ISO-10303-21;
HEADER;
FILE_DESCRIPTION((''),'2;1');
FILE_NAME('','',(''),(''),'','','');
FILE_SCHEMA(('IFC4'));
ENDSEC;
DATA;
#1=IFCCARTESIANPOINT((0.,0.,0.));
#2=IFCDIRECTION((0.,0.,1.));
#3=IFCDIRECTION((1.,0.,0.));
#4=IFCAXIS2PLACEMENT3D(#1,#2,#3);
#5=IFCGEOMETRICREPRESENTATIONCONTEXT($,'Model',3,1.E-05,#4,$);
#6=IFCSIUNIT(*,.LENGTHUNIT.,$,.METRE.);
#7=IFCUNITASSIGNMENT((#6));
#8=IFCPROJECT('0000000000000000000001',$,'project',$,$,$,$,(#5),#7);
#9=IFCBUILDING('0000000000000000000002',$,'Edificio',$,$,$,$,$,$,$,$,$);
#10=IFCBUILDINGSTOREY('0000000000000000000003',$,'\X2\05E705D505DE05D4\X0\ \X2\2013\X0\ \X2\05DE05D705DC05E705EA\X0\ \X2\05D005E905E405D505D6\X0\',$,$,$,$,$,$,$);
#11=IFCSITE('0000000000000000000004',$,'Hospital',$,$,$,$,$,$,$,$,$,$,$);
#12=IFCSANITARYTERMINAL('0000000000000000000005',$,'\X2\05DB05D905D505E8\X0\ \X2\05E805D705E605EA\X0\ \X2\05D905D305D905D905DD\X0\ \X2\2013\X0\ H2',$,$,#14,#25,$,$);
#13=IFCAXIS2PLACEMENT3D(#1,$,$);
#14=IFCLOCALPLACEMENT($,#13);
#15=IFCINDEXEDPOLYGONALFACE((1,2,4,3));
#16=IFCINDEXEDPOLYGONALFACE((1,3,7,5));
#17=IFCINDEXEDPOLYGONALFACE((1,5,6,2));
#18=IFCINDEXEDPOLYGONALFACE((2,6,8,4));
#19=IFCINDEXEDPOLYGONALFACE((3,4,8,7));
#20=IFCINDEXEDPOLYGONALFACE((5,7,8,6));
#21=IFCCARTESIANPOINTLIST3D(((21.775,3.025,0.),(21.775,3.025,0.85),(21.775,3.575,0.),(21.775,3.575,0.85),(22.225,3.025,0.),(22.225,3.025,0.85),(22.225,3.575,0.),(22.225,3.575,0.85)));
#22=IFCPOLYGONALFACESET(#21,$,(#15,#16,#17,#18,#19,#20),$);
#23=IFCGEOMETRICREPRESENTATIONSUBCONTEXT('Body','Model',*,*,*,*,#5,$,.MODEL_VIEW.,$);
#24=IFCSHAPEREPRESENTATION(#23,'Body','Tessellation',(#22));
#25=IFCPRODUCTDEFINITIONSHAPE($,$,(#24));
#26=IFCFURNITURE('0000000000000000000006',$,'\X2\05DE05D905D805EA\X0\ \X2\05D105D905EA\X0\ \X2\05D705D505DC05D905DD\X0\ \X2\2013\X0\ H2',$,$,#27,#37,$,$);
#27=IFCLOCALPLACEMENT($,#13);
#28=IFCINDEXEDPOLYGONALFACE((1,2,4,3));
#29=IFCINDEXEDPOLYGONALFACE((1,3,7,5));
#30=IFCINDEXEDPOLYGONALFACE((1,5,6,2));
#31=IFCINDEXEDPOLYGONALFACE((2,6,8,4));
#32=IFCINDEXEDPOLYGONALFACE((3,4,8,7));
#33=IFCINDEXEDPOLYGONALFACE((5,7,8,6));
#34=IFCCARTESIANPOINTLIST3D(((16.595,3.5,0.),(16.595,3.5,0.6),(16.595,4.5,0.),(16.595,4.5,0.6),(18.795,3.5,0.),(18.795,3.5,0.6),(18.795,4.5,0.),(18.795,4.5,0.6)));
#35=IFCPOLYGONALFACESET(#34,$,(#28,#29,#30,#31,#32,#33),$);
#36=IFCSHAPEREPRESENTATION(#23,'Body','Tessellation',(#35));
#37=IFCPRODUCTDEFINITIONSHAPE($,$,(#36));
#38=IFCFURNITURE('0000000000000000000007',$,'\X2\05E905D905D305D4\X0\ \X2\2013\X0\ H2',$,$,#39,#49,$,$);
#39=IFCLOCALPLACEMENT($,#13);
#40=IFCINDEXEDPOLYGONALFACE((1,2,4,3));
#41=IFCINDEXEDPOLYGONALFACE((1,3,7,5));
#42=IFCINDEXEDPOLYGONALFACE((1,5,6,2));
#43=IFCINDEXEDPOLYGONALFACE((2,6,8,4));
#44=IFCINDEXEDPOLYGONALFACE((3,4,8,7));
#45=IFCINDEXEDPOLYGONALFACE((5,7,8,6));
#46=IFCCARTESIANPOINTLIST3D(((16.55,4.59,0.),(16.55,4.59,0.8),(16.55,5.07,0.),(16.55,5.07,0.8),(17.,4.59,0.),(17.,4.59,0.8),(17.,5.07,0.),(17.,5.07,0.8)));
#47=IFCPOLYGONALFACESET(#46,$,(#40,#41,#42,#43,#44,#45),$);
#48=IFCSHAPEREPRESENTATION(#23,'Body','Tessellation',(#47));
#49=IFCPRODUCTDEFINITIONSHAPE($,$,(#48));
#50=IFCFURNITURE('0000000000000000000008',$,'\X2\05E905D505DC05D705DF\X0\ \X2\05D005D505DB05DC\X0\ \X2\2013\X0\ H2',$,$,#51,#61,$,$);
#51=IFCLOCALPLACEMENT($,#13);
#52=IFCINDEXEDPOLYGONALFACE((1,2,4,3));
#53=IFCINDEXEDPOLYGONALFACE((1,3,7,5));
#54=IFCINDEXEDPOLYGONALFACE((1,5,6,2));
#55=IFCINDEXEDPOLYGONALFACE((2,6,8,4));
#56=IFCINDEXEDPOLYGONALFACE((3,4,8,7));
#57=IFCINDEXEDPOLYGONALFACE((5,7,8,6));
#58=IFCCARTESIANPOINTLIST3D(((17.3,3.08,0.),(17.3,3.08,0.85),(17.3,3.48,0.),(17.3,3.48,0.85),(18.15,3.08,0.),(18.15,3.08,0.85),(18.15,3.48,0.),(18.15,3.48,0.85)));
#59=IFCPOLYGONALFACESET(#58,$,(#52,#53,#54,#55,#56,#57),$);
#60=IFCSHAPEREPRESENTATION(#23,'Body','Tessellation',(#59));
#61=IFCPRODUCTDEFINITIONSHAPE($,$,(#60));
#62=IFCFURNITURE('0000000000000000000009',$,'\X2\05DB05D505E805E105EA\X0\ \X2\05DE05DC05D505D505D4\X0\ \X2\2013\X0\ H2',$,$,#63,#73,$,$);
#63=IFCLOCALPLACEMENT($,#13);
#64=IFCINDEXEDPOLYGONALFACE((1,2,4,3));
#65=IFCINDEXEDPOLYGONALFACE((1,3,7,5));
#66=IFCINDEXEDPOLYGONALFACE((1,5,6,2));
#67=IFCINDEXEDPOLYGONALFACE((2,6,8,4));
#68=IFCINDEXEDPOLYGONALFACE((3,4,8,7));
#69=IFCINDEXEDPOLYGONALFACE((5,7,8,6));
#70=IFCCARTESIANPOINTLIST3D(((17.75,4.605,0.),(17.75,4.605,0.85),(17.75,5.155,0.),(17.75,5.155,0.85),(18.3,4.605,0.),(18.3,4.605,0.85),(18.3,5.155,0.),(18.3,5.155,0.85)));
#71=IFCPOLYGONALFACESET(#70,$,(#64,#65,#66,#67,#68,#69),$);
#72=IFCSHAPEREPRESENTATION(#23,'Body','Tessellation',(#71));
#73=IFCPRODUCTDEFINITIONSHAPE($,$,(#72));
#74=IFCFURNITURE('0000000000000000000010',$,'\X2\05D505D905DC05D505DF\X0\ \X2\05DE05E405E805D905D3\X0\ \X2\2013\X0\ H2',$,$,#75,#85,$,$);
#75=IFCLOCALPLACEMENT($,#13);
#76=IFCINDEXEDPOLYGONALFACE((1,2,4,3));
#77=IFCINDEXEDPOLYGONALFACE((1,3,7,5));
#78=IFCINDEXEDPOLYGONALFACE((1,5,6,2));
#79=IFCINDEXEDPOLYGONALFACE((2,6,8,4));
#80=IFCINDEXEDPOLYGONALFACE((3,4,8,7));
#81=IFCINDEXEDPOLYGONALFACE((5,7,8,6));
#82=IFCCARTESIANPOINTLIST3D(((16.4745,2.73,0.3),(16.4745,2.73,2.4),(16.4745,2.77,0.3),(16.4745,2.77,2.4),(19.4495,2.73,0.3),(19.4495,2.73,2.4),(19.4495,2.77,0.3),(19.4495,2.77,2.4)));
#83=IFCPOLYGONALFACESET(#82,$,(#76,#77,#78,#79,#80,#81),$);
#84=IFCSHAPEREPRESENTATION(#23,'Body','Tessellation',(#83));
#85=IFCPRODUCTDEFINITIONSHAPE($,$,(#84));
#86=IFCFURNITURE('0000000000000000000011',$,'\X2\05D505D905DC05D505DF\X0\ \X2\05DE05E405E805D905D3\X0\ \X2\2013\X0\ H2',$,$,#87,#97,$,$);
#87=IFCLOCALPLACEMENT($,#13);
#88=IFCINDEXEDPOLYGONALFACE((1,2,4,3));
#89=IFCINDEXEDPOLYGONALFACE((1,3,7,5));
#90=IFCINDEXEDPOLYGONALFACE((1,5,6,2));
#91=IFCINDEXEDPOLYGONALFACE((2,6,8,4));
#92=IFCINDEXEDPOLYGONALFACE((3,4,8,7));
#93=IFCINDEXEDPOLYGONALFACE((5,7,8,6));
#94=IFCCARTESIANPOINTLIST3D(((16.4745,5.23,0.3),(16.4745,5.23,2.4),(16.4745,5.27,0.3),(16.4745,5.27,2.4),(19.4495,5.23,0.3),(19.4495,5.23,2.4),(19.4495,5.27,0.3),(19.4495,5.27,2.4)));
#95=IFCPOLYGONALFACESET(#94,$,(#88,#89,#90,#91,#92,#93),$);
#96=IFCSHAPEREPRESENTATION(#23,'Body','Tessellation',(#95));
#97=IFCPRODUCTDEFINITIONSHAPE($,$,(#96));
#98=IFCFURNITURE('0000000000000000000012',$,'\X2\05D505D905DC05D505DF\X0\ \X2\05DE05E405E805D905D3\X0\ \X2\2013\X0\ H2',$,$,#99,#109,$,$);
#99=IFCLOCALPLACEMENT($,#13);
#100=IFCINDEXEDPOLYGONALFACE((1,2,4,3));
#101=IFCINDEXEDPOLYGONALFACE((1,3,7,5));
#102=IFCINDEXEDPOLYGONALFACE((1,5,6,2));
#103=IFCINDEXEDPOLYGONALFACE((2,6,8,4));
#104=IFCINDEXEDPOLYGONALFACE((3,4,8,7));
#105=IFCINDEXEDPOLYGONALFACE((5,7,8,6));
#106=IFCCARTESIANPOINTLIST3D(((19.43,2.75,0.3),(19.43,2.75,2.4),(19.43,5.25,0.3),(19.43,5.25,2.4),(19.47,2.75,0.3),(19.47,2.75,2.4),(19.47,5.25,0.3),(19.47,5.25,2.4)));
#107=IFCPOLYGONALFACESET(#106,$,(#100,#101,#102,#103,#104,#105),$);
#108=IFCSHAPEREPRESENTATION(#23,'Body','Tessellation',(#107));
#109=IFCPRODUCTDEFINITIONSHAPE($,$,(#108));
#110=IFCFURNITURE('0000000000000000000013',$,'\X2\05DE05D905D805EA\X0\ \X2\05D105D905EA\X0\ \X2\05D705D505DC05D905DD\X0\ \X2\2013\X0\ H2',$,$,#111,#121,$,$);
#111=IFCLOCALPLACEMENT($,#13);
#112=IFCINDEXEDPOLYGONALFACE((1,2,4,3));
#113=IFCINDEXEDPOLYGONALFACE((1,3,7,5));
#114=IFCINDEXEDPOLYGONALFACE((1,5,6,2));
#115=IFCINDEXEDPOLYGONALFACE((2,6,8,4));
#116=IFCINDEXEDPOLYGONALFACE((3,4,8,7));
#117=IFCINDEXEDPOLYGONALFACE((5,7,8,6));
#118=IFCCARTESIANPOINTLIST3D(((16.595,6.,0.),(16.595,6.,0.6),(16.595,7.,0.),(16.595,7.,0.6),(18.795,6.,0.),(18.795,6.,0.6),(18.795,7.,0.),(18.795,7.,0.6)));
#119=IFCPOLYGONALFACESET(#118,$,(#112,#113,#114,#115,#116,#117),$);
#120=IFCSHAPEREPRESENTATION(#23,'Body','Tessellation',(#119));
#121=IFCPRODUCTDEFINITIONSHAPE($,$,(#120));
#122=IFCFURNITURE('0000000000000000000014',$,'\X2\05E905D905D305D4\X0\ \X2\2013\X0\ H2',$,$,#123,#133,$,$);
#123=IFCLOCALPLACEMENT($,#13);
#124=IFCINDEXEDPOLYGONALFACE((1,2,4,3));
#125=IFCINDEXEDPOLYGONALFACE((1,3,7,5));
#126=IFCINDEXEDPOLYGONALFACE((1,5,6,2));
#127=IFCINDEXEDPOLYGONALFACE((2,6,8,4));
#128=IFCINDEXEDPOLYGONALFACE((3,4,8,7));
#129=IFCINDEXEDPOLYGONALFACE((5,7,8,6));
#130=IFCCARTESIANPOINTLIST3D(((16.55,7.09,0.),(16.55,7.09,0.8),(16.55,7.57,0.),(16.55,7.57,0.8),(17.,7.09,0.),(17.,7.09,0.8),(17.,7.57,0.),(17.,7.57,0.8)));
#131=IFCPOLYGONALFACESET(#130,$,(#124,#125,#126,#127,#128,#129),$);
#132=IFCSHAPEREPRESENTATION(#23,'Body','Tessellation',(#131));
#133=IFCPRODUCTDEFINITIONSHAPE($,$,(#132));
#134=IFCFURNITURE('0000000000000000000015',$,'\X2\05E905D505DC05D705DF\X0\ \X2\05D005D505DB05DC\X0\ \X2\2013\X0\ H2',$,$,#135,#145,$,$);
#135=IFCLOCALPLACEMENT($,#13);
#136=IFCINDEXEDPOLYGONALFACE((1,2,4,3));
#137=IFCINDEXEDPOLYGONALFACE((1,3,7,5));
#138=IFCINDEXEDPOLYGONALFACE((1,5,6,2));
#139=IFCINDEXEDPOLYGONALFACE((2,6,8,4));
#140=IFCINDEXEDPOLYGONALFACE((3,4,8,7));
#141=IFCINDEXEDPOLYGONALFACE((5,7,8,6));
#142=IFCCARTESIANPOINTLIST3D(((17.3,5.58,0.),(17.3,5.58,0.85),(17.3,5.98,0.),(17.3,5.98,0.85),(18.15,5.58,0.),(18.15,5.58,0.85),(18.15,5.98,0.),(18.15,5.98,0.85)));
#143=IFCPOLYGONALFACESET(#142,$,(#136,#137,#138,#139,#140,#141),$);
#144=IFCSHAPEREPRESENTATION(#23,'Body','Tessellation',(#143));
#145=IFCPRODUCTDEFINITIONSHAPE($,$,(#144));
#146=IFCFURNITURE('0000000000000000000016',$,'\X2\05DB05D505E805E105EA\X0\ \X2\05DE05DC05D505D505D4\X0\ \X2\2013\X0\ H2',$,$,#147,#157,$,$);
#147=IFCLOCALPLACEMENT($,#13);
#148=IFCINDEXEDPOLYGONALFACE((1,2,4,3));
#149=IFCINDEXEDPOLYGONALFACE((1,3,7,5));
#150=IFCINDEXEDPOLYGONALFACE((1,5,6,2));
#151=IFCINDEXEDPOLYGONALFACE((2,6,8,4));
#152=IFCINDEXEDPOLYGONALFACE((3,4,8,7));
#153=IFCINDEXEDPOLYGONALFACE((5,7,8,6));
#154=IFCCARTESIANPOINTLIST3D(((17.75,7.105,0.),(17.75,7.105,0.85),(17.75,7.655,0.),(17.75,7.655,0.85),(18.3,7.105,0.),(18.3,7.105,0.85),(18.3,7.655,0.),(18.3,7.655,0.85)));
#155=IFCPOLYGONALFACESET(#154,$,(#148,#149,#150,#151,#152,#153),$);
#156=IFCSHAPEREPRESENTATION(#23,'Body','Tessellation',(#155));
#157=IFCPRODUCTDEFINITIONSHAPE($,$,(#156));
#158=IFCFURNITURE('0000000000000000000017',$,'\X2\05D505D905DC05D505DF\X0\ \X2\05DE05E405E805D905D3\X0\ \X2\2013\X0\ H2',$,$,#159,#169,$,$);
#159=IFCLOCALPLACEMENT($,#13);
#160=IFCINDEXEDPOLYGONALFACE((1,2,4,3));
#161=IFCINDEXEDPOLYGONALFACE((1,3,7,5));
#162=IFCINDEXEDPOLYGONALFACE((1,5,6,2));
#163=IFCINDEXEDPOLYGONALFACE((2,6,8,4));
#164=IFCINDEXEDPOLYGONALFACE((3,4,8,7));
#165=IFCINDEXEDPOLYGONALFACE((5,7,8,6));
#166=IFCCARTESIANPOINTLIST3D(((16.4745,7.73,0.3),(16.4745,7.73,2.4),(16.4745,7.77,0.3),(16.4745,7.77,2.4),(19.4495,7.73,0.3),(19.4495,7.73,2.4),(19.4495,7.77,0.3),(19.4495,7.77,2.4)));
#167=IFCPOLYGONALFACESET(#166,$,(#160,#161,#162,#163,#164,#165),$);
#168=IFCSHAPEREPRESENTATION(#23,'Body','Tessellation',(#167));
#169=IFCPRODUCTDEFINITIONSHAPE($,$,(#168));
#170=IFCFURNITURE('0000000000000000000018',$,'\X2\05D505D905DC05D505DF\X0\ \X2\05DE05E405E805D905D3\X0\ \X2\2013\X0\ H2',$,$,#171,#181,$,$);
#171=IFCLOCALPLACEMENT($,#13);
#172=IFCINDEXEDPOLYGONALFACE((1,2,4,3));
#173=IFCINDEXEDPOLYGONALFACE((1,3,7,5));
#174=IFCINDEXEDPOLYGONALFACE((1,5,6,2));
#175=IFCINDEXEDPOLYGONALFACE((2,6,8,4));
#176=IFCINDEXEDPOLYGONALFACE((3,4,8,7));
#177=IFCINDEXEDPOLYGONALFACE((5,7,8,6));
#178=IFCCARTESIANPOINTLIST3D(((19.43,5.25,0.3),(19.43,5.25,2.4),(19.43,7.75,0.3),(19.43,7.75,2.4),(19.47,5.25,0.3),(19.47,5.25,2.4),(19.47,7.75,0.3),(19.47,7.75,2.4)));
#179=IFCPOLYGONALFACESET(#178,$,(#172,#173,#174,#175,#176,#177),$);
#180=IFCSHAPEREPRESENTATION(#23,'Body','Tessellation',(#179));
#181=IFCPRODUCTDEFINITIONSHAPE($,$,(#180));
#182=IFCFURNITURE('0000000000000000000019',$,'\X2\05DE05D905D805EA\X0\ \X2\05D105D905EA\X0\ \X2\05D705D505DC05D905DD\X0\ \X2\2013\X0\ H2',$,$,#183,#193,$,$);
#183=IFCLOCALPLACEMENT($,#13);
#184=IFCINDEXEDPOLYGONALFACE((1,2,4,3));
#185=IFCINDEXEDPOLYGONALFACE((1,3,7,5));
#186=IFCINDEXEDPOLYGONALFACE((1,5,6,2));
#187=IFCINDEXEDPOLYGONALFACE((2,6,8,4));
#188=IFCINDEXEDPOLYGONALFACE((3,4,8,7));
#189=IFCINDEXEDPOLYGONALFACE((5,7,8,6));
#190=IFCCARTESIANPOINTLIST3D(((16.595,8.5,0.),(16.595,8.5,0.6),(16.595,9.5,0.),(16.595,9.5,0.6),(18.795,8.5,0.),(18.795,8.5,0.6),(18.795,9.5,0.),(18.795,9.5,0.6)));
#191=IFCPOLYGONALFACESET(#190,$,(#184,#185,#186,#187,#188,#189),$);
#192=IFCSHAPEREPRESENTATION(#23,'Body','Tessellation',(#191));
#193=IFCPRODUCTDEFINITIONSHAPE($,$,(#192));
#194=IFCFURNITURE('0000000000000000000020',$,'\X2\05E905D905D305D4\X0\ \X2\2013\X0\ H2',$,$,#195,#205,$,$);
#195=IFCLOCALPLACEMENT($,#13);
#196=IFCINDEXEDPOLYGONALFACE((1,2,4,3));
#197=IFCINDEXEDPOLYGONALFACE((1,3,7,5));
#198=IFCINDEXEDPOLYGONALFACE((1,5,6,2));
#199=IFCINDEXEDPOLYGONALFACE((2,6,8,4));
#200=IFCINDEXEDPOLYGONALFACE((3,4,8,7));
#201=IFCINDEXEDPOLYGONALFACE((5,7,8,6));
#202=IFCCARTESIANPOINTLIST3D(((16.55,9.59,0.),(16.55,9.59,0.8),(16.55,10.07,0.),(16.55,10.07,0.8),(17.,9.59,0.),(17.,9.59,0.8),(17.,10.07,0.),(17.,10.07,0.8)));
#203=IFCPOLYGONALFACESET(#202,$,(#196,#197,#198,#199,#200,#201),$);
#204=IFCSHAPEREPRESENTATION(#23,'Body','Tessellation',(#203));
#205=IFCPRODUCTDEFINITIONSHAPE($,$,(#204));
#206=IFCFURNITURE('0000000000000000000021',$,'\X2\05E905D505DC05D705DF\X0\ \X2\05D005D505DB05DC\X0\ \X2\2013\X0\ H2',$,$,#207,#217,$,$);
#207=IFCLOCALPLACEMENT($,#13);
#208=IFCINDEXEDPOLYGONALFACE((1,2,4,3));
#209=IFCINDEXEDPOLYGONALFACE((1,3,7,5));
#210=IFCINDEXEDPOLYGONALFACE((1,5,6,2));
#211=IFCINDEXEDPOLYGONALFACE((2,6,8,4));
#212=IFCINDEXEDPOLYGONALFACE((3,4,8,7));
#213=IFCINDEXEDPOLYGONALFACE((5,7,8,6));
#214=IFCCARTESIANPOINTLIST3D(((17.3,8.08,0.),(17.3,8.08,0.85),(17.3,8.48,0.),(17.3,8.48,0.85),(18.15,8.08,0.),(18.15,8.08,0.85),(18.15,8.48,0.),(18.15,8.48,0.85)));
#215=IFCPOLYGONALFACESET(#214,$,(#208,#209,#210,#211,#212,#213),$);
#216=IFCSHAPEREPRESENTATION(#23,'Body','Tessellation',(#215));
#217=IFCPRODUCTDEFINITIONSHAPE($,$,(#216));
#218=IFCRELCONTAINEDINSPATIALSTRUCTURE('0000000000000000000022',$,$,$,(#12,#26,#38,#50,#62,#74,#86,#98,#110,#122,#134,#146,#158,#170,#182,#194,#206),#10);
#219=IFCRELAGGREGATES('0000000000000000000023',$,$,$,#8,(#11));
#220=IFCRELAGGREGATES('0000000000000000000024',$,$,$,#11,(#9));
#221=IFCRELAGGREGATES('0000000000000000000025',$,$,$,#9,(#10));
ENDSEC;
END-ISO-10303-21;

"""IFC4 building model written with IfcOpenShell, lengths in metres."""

from ifc_helpers import new_model, si_unit, frame, origin_with_axes, context, subcontext, project, spatial, line, indexed_curve, outline, extrude, element, save


model = new_model("IFC4")

# Units and contexts
model_context = context("Model", 3, precision=1e-05, world=origin_with_axes())
body_context = subcontext(model_context, "Body", "Model", "MODEL_VIEW")
ifc_project = project(units=[si_unit("LENGTHUNIT", "METRE")], contexts=[model_context])

# Site, building, storey
site = spatial("IfcSite", under=ifc_project, Name="Hospital")
building = spatial("IfcBuilding", under=site, Name="Edificio")
storey = spatial("IfcBuildingStorey", under=building, Name="קומה – מחלקת אשפוז")

# Sanitary terminal
element("IfcSanitaryTerminal", 1, inside=storey, Name="כיור רחצת ידיים – H2", context=body_context, shape_type="SweptSolid", body=[
    extrude(outline(indexed_curve([(0.0, 0.0), (0.45, 0.0), (0.45, 0.55), (0.0, 0.55)], segments=[line(1, 2, 3, 4, 1)])), frame((21.775, 3.025, 0.0), z_axis=(0.0, 0.0, 1.0), x_axis=(1.0, 0.0, 0.0)), (0.0, 0.0, 1.0), 0.85),
])

# Furniture
element("IfcFurniture", 2, inside=storey, Name="מיטת בית חולים – H2", context=body_context, shape_type="SweptSolid", body=[
    extrude(outline(indexed_curve([(0.0, 0.0), (2.2, 0.0), (2.2, 1.0), (0.0, 1.0)], segments=[line(1, 2, 3, 4, 1)])), frame((16.595, 3.5, 0.0), z_axis=(0.0, 0.0, 1.0), x_axis=(1.0, 0.0, 0.0)), (0.0, 0.0, 1.0), 0.6),
])
element("IfcFurniture", 3, inside=storey, Name="שידה – H2", context=body_context, shape_type="SweptSolid", body=[
    extrude(outline(indexed_curve([(0.0, 0.0), (0.45, 0.0), (0.45, 0.48), (0.0, 0.48)], segments=[line(1, 2, 3, 4, 1)])), frame((16.55, 4.59, 0.0), z_axis=(0.0, 0.0, 1.0), x_axis=(1.0, 0.0, 0.0)), (0.0, 0.0, 1.0), 0.8),
])
element("IfcFurniture", 4, inside=storey, Name="שולחן אוכל – H2", context=body_context, shape_type="SweptSolid", body=[
    extrude(outline(indexed_curve([(0.0, 0.0), (0.85, 0.0), (0.85, 0.4), (0.0, 0.4)], segments=[line(1, 2, 3, 4, 1)])), frame((17.3, 3.08, 0.0), z_axis=(0.0, 0.0, 1.0), x_axis=(1.0, 0.0, 0.0)), (0.0, 0.0, 1.0), 0.85),
])
element("IfcFurniture", 5, inside=storey, Name="כורסת מלווה – H2", context=body_context, shape_type="SweptSolid", body=[
    extrude(outline(indexed_curve([(0.0, 0.0), (0.55, 0.0), (0.55, 0.55), (0.0, 0.55)], segments=[line(1, 2, 3, 4, 1)])), frame((17.75, 4.605, 0.0), z_axis=(0.0, 0.0, 1.0), x_axis=(1.0, 0.0, 0.0)), (0.0, 0.0, 1.0), 0.85),
])
element("IfcFurniture", 6, inside=storey, Name="וילון מפריד – H2", context=body_context, shape_type="SweptSolid", body=[
    extrude(outline(indexed_curve([(0.0, 0.0), (2.975, 0.0), (2.975, 0.04), (0.0, 0.04)], segments=[line(1, 2, 3, 4, 1)])), frame((16.4745, 2.73, 0.3), z_axis=(0.0, 0.0, 1.0), x_axis=(1.0, 0.0, 0.0)), (0.0, 0.0, 1.0), 2.1),
])
element("IfcFurniture", 7, inside=storey, Name="וילון מפריד – H2", context=body_context, shape_type="SweptSolid", body=[
    extrude(outline(indexed_curve([(0.0, 0.0), (2.975, 0.0), (2.975, 0.04), (0.0, 0.04)], segments=[line(1, 2, 3, 4, 1)])), frame((16.4745, 5.23, 0.3), z_axis=(0.0, 0.0, 1.0), x_axis=(1.0, 0.0, 0.0)), (0.0, 0.0, 1.0), 2.1),
])
element("IfcFurniture", 8, inside=storey, Name="וילון מפריד – H2", context=body_context, shape_type="SweptSolid", body=[
    extrude(outline(indexed_curve([(0.0, 0.0), (0.04, 0.0), (0.04, 2.5), (0.0, 2.5)], segments=[line(1, 2, 3, 4, 1)])), frame((19.43, 2.75, 0.3), z_axis=(0.0, 0.0, 1.0), x_axis=(1.0, 0.0, 0.0)), (0.0, 0.0, 1.0), 2.1),
])
element("IfcFurniture", 9, inside=storey, Name="מיטת בית חולים – H2", context=body_context, shape_type="SweptSolid", body=[
    extrude(outline(indexed_curve([(0.0, 0.0), (2.2, 0.0), (2.2, 1.0), (0.0, 1.0)], segments=[line(1, 2, 3, 4, 1)])), frame((16.595, 6.0, 0.0), z_axis=(0.0, 0.0, 1.0), x_axis=(1.0, 0.0, 0.0)), (0.0, 0.0, 1.0), 0.6),
])
element("IfcFurniture", 10, inside=storey, Name="שידה – H2", context=body_context, shape_type="SweptSolid", body=[
    extrude(outline(indexed_curve([(0.0, 0.0), (0.45, 0.0), (0.45, 0.48), (0.0, 0.48)], segments=[line(1, 2, 3, 4, 1)])), frame((16.55, 7.09, 0.0), z_axis=(0.0, 0.0, 1.0), x_axis=(1.0, 0.0, 0.0)), (0.0, 0.0, 1.0), 0.8),
])
element("IfcFurniture", 11, inside=storey, Name="שולחן אוכל – H2", context=body_context, shape_type="SweptSolid", body=[
    extrude(outline(indexed_curve([(0.0, 0.0), (0.85, 0.0), (0.85, 0.4), (0.0, 0.4)], segments=[line(1, 2, 3, 4, 1)])), frame((17.3, 5.58, 0.0), z_axis=(0.0, 0.0, 1.0), x_axis=(1.0, 0.0, 0.0)), (0.0, 0.0, 1.0), 0.85),
])
element("IfcFurniture", 12, inside=storey, Name="כורסת מלווה – H2", context=body_context, shape_type="SweptSolid", body=[
    extrude(outline(indexed_curve([(0.0, 0.0), (0.55, 0.0), (0.55, 0.55), (0.0, 0.55)], segments=[line(1, 2, 3, 4, 1)])), frame((17.75, 7.105, 0.0), z_axis=(0.0, 0.0, 1.0), x_axis=(1.0, 0.0, 0.0)), (0.0, 0.0, 1.0), 0.85),
])
element("IfcFurniture", 13, inside=storey, Name="וילון מפריד – H2", context=body_context, shape_type="SweptSolid", body=[
    extrude(outline(indexed_curve([(0.0, 0.0), (2.975, 0.0), (2.975, 0.04), (0.0, 0.04)], segments=[line(1, 2, 3, 4, 1)])), frame((16.4745, 7.73, 0.3), z_axis=(0.0, 0.0, 1.0), x_axis=(1.0, 0.0, 0.0)), (0.0, 0.0, 1.0), 2.1),
])
element("IfcFurniture", 14, inside=storey, Name="וילון מפריד – H2", context=body_context, shape_type="SweptSolid", body=[
    extrude(outline(indexed_curve([(0.0, 0.0), (0.04, 0.0), (0.04, 2.5), (0.0, 2.5)], segments=[line(1, 2, 3, 4, 1)])), frame((19.43, 5.25, 0.3), z_axis=(0.0, 0.0, 1.0), x_axis=(1.0, 0.0, 0.0)), (0.0, 0.0, 1.0), 2.1),
])
element("IfcFurniture", 15, inside=storey, Name="מיטת בית חולים – H2", context=body_context, shape_type="SweptSolid", body=[
    extrude(outline(indexed_curve([(0.0, 0.0), (2.2, 0.0), (2.2, 1.0), (0.0, 1.0)], segments=[line(1, 2, 3, 4, 1)])), frame((16.595, 8.5, 0.0), z_axis=(0.0, 0.0, 1.0), x_axis=(1.0, 0.0, 0.0)), (0.0, 0.0, 1.0), 0.6),
])
element("IfcFurniture", 16, inside=storey, Name="שידה – H2", context=body_context, shape_type="SweptSolid", body=[
    extrude(outline(indexed_curve([(0.0, 0.0), (0.45, 0.0), (0.45, 0.48), (0.0, 0.48)], segments=[line(1, 2, 3, 4, 1)])), frame((16.55, 9.59, 0.0), z_axis=(0.0, 0.0, 1.0), x_axis=(1.0, 0.0, 0.0)), (0.0, 0.0, 1.0), 0.8),
])
element("IfcFurniture", 17, inside=storey, Name="שולחן אוכל – H2", context=body_context, shape_type="SweptSolid", body=[
    extrude(outline(indexed_curve([(0.0, 0.0), (0.85, 0.0), (0.85, 0.4), (0.0, 0.4)], segments=[line(1, 2, 3, 4, 1)])), frame((17.3, 8.08, 0.0), z_axis=(0.0, 0.0, 1.0), x_axis=(1.0, 0.0, 0.0)), (0.0, 0.0, 1.0), 0.85),
])

save(model, "model.ifc")
